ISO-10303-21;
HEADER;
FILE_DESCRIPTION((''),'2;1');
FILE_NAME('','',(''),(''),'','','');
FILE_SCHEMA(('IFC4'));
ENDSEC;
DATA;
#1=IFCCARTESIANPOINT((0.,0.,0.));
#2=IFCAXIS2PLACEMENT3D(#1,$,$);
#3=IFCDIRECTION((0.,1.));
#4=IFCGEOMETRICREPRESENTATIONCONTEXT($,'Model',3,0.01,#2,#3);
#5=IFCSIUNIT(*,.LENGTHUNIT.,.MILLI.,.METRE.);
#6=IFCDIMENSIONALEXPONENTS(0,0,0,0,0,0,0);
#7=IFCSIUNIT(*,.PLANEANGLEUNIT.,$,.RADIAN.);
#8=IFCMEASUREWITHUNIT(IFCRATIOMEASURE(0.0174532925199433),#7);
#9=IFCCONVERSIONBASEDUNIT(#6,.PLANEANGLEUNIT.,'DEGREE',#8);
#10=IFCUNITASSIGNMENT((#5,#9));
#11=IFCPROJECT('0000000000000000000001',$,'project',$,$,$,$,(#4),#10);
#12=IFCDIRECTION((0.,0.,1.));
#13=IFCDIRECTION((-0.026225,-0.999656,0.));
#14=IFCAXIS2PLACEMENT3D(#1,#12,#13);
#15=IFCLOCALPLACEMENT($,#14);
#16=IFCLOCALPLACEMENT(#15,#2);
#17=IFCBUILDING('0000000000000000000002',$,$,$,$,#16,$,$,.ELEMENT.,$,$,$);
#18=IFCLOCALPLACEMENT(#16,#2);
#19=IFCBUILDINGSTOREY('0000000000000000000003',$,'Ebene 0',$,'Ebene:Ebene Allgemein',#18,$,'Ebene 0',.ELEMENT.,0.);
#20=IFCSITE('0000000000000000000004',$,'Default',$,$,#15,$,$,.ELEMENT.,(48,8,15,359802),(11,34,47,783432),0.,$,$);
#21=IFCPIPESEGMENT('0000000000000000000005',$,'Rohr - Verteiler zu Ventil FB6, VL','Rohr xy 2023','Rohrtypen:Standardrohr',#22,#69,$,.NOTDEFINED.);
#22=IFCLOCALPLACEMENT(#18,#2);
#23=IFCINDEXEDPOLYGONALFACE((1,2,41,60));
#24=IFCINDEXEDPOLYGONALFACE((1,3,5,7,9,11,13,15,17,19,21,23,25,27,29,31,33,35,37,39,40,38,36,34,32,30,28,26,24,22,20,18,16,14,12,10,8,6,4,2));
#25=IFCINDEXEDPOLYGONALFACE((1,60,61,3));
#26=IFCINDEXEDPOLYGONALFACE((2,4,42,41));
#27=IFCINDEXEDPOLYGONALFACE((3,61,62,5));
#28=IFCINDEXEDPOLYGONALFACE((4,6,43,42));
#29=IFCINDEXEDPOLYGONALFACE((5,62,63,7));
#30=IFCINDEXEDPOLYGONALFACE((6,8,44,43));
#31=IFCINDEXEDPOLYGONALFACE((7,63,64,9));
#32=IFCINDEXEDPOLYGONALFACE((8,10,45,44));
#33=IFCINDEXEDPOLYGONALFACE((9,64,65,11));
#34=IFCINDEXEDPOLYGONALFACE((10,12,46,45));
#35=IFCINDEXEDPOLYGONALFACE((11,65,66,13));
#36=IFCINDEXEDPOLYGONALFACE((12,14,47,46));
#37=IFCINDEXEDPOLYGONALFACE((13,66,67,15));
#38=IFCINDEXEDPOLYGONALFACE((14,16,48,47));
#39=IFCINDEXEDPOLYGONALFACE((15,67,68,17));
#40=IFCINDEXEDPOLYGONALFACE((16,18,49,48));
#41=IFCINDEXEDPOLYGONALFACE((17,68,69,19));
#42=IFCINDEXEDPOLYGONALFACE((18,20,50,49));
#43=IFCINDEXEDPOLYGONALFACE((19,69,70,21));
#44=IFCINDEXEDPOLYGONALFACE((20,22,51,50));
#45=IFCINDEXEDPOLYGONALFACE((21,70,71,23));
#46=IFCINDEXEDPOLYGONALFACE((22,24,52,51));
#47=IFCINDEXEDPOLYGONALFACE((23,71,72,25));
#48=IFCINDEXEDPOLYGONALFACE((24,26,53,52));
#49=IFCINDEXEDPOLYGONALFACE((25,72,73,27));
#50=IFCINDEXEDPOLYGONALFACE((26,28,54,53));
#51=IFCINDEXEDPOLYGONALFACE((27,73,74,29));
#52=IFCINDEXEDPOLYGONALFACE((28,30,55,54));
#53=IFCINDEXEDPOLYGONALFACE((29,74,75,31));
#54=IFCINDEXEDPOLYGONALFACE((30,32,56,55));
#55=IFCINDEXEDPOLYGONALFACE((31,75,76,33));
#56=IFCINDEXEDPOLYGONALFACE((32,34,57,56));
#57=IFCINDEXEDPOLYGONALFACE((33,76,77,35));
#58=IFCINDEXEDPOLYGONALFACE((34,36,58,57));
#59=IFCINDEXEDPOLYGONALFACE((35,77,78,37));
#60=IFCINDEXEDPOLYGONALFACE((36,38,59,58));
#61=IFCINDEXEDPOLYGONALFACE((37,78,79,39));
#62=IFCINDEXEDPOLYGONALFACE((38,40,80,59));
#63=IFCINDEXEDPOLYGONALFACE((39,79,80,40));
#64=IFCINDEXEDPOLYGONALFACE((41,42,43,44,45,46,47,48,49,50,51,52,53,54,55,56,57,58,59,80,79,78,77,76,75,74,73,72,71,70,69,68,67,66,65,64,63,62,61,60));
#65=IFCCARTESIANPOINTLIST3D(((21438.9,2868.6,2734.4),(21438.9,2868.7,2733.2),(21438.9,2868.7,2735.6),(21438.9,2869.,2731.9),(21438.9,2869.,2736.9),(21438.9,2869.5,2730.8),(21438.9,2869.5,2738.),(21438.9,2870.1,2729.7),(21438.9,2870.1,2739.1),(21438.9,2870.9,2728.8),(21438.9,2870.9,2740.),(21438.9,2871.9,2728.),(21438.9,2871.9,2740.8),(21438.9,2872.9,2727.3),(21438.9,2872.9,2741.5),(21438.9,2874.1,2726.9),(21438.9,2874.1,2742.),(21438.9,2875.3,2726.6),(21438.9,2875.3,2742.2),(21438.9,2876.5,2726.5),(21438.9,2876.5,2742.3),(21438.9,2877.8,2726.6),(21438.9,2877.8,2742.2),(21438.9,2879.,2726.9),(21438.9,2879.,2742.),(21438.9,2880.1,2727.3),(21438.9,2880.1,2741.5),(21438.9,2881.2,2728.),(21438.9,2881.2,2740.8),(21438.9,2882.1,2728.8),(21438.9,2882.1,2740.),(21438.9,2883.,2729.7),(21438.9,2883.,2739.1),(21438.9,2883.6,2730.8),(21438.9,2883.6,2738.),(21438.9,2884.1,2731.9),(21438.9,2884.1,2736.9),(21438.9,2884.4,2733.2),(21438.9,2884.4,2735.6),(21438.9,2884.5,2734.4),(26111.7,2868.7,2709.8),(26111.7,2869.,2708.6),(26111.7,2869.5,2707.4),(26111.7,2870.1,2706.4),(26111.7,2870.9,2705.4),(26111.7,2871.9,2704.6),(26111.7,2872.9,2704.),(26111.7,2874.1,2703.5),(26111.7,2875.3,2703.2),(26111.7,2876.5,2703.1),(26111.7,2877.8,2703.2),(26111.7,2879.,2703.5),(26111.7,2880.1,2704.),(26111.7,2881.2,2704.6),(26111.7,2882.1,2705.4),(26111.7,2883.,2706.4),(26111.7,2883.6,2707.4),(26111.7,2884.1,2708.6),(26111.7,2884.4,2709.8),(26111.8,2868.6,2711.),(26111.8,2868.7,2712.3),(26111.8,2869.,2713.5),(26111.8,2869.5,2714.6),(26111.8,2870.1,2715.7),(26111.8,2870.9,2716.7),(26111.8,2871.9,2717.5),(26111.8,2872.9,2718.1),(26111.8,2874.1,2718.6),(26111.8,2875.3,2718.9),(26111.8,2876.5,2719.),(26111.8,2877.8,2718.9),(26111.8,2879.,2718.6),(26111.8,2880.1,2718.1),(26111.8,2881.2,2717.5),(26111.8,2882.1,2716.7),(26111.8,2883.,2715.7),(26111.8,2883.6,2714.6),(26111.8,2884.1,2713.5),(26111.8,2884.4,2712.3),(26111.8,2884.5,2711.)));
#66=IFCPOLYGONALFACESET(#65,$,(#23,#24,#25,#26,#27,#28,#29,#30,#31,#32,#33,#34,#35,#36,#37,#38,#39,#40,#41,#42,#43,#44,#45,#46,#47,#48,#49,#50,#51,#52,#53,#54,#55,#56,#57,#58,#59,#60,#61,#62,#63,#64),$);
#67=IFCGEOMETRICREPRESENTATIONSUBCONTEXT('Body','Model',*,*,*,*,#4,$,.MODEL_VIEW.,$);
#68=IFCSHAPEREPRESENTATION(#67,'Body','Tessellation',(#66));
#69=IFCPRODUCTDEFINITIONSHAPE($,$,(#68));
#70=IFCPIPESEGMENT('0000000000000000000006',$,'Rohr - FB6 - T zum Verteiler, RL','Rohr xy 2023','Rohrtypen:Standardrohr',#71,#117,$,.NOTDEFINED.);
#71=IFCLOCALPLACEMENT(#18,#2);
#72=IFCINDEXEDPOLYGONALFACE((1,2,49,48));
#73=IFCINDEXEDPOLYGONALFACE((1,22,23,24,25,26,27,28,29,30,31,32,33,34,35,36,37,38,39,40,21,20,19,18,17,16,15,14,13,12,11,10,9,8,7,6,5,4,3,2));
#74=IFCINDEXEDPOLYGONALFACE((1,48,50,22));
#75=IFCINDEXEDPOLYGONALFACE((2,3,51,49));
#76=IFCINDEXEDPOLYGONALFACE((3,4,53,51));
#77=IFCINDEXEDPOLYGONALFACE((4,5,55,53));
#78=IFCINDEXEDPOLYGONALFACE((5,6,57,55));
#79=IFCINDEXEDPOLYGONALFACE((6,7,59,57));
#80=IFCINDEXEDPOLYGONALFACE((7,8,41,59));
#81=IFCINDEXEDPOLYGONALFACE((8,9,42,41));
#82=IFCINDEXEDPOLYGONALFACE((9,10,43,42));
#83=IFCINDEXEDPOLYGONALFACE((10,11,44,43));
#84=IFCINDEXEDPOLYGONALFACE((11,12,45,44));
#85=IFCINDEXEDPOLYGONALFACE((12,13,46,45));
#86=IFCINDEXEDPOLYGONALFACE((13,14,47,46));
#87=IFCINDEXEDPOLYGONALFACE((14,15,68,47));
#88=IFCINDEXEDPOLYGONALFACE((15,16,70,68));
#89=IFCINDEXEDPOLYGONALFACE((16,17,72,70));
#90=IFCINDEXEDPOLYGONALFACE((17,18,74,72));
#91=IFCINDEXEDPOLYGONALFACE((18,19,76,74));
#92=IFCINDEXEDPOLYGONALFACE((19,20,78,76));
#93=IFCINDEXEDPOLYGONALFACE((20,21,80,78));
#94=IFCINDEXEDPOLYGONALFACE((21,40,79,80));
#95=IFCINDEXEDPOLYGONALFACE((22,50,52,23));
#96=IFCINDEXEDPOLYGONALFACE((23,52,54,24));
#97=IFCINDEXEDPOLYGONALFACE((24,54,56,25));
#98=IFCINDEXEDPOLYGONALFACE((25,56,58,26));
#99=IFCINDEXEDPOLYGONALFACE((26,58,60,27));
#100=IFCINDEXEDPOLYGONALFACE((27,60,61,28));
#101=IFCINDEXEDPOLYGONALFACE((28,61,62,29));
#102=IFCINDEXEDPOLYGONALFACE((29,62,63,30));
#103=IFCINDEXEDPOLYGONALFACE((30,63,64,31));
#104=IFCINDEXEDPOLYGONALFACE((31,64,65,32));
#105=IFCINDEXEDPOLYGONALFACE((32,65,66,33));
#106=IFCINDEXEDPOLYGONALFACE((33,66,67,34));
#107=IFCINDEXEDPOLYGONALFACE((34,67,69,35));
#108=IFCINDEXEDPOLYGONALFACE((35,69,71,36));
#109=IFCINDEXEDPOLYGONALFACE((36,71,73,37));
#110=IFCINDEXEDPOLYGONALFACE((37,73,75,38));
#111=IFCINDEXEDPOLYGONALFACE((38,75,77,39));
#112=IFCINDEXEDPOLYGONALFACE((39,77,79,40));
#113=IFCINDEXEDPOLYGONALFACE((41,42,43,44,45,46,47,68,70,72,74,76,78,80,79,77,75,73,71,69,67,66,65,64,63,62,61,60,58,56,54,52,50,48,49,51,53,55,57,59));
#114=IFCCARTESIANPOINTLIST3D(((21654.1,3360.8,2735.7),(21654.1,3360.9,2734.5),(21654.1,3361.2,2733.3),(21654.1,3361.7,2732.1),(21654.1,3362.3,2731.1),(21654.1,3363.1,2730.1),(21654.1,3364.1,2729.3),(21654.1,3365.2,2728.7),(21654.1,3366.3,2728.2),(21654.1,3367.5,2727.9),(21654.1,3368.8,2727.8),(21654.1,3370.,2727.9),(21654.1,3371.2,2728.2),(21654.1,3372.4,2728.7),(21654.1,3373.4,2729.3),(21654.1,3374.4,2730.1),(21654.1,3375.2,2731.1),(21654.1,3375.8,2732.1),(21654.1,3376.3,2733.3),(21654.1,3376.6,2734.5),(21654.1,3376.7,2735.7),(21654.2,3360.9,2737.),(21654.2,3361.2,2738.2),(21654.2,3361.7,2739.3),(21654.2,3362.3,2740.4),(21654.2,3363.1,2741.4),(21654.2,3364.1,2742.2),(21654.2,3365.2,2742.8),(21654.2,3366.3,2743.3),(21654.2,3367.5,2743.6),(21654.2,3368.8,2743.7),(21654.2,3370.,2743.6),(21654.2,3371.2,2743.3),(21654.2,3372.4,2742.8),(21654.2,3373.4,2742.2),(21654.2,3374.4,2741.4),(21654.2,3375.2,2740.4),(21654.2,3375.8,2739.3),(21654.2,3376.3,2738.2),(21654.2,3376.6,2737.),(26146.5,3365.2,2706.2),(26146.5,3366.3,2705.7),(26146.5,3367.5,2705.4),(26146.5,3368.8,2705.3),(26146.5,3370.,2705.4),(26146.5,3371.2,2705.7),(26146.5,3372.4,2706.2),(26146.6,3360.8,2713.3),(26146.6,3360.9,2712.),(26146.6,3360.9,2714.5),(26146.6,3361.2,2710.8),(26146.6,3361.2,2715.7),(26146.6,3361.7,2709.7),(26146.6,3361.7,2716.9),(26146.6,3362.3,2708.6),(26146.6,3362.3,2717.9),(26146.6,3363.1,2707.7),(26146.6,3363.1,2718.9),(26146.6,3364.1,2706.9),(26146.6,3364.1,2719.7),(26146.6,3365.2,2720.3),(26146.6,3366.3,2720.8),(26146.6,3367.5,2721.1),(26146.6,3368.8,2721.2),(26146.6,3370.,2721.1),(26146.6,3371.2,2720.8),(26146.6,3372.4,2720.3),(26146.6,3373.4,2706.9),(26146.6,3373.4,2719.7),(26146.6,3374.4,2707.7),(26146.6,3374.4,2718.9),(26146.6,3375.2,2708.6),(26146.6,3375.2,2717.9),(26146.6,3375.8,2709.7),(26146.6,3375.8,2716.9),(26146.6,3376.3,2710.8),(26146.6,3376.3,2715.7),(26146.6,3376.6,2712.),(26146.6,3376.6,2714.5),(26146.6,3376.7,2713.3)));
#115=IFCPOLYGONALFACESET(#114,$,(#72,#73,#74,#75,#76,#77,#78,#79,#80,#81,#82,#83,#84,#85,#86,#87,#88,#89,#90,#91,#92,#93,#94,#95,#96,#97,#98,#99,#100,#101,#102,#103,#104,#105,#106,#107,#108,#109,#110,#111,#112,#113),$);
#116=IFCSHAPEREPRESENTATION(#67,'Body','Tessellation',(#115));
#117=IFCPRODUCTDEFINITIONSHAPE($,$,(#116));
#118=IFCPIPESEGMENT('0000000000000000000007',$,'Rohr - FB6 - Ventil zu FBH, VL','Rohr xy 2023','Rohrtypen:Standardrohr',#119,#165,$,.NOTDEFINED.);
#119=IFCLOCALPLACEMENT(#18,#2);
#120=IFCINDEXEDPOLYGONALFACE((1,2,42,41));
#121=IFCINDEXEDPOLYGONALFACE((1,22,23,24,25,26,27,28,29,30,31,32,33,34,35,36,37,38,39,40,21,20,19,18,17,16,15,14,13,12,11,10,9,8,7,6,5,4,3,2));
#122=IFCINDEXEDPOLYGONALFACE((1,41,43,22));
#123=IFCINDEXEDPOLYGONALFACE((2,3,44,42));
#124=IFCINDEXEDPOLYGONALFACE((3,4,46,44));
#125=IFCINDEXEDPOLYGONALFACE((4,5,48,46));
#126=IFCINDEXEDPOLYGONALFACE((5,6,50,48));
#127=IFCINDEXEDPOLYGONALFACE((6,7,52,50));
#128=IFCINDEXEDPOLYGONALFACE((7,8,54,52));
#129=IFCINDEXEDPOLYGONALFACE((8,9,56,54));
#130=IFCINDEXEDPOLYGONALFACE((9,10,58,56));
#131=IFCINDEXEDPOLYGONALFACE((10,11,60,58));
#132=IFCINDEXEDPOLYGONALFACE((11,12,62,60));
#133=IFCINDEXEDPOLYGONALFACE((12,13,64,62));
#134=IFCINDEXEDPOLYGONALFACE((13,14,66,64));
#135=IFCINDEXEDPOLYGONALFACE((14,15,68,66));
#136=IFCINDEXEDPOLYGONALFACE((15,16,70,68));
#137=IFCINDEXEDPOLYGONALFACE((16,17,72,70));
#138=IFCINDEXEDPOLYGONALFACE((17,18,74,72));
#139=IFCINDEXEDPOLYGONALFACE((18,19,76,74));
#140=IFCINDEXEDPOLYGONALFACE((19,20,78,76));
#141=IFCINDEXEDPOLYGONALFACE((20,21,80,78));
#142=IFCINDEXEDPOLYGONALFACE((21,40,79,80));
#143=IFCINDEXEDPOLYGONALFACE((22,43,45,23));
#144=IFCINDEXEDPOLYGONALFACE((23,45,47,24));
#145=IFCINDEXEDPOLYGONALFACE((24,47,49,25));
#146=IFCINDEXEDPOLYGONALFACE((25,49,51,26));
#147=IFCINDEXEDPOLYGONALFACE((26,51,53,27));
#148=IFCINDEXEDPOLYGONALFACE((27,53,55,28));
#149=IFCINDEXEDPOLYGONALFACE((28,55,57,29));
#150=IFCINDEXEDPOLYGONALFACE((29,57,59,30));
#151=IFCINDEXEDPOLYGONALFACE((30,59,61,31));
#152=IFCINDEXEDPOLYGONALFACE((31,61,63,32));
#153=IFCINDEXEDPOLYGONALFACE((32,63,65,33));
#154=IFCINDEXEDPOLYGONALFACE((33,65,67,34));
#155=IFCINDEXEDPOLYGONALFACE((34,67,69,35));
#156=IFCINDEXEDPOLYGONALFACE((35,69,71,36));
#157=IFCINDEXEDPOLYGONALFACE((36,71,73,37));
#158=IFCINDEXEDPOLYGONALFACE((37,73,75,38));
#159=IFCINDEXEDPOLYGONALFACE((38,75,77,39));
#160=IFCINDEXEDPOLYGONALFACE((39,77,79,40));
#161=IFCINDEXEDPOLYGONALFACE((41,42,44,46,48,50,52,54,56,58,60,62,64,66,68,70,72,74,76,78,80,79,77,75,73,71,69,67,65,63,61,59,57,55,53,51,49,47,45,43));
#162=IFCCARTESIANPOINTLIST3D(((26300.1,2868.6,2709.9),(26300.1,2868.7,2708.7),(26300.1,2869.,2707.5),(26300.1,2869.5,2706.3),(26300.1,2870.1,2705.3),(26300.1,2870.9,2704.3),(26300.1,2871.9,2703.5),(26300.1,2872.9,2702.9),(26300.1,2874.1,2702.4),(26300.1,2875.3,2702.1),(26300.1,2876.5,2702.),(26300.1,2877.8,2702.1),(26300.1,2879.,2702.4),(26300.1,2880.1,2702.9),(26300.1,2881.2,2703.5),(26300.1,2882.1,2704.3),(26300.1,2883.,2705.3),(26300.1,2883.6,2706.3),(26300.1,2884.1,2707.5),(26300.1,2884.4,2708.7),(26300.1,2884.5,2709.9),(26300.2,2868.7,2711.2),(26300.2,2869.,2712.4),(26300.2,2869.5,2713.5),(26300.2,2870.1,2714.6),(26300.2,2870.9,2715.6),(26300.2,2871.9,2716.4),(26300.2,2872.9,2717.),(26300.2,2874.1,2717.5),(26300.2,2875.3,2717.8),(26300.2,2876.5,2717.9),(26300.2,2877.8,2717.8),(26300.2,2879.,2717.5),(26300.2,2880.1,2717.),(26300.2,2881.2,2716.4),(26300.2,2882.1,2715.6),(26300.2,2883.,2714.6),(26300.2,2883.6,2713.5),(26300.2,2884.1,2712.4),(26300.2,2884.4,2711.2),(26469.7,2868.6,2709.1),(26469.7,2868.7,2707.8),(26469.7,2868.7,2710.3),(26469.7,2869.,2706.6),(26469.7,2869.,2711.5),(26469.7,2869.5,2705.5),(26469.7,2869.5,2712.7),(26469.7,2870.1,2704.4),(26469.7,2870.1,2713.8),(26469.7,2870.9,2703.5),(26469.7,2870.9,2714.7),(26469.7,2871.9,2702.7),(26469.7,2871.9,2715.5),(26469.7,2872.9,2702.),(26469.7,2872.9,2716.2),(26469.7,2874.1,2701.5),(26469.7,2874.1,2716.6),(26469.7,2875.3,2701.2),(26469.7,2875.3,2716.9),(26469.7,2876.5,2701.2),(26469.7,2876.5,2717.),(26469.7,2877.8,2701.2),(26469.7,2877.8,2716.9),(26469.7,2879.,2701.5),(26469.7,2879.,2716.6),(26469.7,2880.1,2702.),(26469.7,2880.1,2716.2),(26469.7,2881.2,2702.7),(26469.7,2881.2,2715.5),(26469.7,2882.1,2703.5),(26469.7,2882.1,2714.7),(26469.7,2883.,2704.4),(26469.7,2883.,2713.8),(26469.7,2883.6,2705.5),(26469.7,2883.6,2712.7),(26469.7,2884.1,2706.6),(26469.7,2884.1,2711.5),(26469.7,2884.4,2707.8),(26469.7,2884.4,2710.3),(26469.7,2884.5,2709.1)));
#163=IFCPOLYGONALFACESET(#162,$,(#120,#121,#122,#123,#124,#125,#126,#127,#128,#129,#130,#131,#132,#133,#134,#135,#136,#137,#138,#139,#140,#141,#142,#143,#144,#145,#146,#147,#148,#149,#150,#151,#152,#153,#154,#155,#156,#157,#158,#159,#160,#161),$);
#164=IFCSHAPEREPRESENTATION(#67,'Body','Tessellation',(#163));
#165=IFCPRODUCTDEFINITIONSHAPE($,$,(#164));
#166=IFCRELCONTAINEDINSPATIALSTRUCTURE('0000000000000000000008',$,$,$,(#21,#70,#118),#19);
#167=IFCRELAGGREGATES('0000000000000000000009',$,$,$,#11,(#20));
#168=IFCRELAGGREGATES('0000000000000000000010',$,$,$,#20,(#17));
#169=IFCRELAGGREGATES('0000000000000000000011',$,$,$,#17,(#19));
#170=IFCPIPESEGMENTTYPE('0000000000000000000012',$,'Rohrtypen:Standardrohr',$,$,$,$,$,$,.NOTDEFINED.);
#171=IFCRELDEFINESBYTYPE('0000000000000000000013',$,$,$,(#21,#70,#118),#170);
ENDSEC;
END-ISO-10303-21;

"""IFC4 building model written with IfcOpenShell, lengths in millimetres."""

from ifc_helpers import new_model, entity, si_unit, converted_unit, direction, frame, origin, place, context, subcontext, project, spatial, indexed_curve, outline, extrude, type_object, element, save


model = new_model("IFC4")

# Units and contexts
model_context = context("Model", 3, precision=0.01, world=origin(), true_north=direction((0.0, 1.0)))
body_context = subcontext(model_context, "Body", "Model", "MODEL_VIEW")
ifc_project = project(units=[si_unit("LENGTHUNIT", "METRE", prefix="MILLI"), converted_unit("PLANEANGLEUNIT", "DEGREE", entity("IfcRatioMeasure", 0.0174532925199433), si_unit("PLANEANGLEUNIT", "RADIAN"), dimensions=[0, 0, 0, 0, 0, 0, 0])], contexts=[model_context])

# Site, building, storey
site_placement = place(None, frame((0.0, 0.0, 0.0), z_axis=(0.0, 0.0, 1.0), x_axis=(-0.026225, -0.999656, 0.0)))
site = spatial("IfcSite", under=ifc_project, at=site_placement, Name="Default", CompositionType="ELEMENT", RefLatitude=(48, 8, 15, 359802), RefLongitude=(11, 34, 47, 783432), RefElevation=0.0)
building_placement = place(site_placement, origin())
building = spatial("IfcBuilding", under=site, at=building_placement, CompositionType="ELEMENT")
storey_placement = place(building_placement, origin())
storey = spatial("IfcBuildingStorey", under=building, at=storey_placement, Name="Ebene 0", ObjectType="Ebene:Ebene Allgemein", LongName="Ebene 0", CompositionType="ELEMENT", Elevation=0.0)

# Pipe segments
pipe_segment_type = type_object("IfcPipeSegmentType", Name="Rohrtypen:Standardrohr", PredefinedType="NOTDEFINED")
pipe_segment_1_placement = place(storey_placement, origin())
element("IfcPipeSegment", 1, at=pipe_segment_1_placement, inside=storey, type_object=pipe_segment_type, Name="Rohr - Verteiler zu Ventil FB6, VL", Description="Rohr xy 2023", ObjectType="Rohrtypen:Standardrohr", PredefinedType="NOTDEFINED", context=body_context, shape_type="SweptSolid", body=[
    extrude(outline(indexed_curve([(7.9, 0.0), (7.8, 1.2), (7.6, 2.5), (7.1, 3.6), (6.4, 4.7), (5.6, 5.6), (4.7, 6.4), (3.6, 7.1), (2.5, 7.6), (1.2, 7.8), (0.0, 7.9), (-1.2, 7.8), (-2.5, 7.6), (-3.6, 7.1), (-4.7, 6.4), (-5.6, 5.6), (-6.4, 4.7), (-7.1, 3.6), (-7.6, 2.5), (-7.8, 1.2), (-7.9, 0.0), (-7.8, -1.2), (-7.6, -2.5), (-7.1, -3.6), (-6.4, -4.7), (-5.6, -5.6), (-4.7, -6.4), (-3.6, -7.1), (-2.5, -7.6), (-1.2, -7.8), (0.0, -7.9), (1.2, -7.8), (2.5, -7.6), (3.6, -7.1), (4.7, -6.4), (5.6, -5.6), (6.4, -4.7), (7.1, -3.6), (7.6, -2.5), (7.8, -1.2), (7.9, 0.0)], self_intersect=False)), frame((26111.8, 2876.5, 2711.0), z_axis=(-0.999988, 0.0, 0.005), x_axis=(0.0, 1.0, 0.0)), (0.0, 0.0, 1.0), 4672.9),
])
pipe_segment_2_placement = place(storey_placement, origin())
element("IfcPipeSegment", 2, at=pipe_segment_2_placement, inside=storey, type_object=pipe_segment_type, Name="Rohr - FB6 - T zum Verteiler, RL", Description="Rohr xy 2023", ObjectType="Rohrtypen:Standardrohr", PredefinedType="NOTDEFINED", context=body_context, shape_type="SweptSolid", body=[
    extrude(outline(indexed_curve([(7.9, 0.0), (7.8, 1.2), (7.6, 2.5), (7.1, 3.6), (6.4, 4.7), (5.6, 5.6), (4.7, 6.4), (3.6, 7.1), (2.5, 7.6), (1.2, 7.8), (0.0, 7.9), (-1.2, 7.8), (-2.5, 7.6), (-3.6, 7.1), (-4.7, 6.4), (-5.6, 5.6), (-6.4, 4.7), (-7.1, 3.6), (-7.6, 2.5), (-7.8, 1.2), (-7.9, 0.0), (-7.8, -1.2), (-7.6, -2.5), (-7.1, -3.6), (-6.4, -4.7), (-5.6, -5.6), (-4.7, -6.4), (-3.6, -7.1), (-2.5, -7.6), (-1.2, -7.8), (0.0, -7.9), (1.2, -7.8), (2.5, -7.6), (3.6, -7.1), (4.7, -6.4), (5.6, -5.6), (6.4, -4.7), (7.1, -3.6), (7.6, -2.5), (7.8, -1.2), (7.9, 0.0)], self_intersect=False)), frame((26146.6, 3368.8, 2713.3), z_axis=(-0.999988, 0.0, 0.005), x_axis=(0.0, 1.0, 0.0)), (0.0, 0.0, 1.0), 4492.5),
])
pipe_segment_3_placement = place(storey_placement, origin())
element("IfcPipeSegment", 3, at=pipe_segment_3_placement, inside=storey, type_object=pipe_segment_type, Name="Rohr - FB6 - Ventil zu FBH, VL", Description="Rohr xy 2023", ObjectType="Rohrtypen:Standardrohr", PredefinedType="NOTDEFINED", context=body_context, shape_type="SweptSolid", body=[
    extrude(outline(indexed_curve([(7.9, 0.0), (7.8, 1.2), (7.6, 2.5), (7.1, 3.6), (6.4, 4.7), (5.6, 5.6), (4.7, 6.4), (3.6, 7.1), (2.5, 7.6), (1.2, 7.8), (0.0, 7.9), (-1.2, 7.8), (-2.5, 7.6), (-3.6, 7.1), (-4.7, 6.4), (-5.6, 5.6), (-6.4, 4.7), (-7.1, 3.6), (-7.6, 2.5), (-7.8, 1.2), (-7.9, 0.0), (-7.8, -1.2), (-7.6, -2.5), (-7.1, -3.6), (-6.4, -4.7), (-5.6, -5.6), (-4.7, -6.4), (-3.6, -7.1), (-2.5, -7.6), (-1.2, -7.8), (0.0, -7.9), (1.2, -7.8), (2.5, -7.6), (3.6, -7.1), (4.7, -6.4), (5.6, -5.6), (6.4, -4.7), (7.1, -3.6), (7.6, -2.5), (7.8, -1.2), (7.9, 0.0)], self_intersect=False)), frame((26300.1, 2876.5, 2709.9), z_axis=(0.999988, 0.0, -0.005), x_axis=(0.0, 1.0, 0.0)), (0.0, 0.0, 1.0), 169.5),
])

save(model, "model.ifc")
